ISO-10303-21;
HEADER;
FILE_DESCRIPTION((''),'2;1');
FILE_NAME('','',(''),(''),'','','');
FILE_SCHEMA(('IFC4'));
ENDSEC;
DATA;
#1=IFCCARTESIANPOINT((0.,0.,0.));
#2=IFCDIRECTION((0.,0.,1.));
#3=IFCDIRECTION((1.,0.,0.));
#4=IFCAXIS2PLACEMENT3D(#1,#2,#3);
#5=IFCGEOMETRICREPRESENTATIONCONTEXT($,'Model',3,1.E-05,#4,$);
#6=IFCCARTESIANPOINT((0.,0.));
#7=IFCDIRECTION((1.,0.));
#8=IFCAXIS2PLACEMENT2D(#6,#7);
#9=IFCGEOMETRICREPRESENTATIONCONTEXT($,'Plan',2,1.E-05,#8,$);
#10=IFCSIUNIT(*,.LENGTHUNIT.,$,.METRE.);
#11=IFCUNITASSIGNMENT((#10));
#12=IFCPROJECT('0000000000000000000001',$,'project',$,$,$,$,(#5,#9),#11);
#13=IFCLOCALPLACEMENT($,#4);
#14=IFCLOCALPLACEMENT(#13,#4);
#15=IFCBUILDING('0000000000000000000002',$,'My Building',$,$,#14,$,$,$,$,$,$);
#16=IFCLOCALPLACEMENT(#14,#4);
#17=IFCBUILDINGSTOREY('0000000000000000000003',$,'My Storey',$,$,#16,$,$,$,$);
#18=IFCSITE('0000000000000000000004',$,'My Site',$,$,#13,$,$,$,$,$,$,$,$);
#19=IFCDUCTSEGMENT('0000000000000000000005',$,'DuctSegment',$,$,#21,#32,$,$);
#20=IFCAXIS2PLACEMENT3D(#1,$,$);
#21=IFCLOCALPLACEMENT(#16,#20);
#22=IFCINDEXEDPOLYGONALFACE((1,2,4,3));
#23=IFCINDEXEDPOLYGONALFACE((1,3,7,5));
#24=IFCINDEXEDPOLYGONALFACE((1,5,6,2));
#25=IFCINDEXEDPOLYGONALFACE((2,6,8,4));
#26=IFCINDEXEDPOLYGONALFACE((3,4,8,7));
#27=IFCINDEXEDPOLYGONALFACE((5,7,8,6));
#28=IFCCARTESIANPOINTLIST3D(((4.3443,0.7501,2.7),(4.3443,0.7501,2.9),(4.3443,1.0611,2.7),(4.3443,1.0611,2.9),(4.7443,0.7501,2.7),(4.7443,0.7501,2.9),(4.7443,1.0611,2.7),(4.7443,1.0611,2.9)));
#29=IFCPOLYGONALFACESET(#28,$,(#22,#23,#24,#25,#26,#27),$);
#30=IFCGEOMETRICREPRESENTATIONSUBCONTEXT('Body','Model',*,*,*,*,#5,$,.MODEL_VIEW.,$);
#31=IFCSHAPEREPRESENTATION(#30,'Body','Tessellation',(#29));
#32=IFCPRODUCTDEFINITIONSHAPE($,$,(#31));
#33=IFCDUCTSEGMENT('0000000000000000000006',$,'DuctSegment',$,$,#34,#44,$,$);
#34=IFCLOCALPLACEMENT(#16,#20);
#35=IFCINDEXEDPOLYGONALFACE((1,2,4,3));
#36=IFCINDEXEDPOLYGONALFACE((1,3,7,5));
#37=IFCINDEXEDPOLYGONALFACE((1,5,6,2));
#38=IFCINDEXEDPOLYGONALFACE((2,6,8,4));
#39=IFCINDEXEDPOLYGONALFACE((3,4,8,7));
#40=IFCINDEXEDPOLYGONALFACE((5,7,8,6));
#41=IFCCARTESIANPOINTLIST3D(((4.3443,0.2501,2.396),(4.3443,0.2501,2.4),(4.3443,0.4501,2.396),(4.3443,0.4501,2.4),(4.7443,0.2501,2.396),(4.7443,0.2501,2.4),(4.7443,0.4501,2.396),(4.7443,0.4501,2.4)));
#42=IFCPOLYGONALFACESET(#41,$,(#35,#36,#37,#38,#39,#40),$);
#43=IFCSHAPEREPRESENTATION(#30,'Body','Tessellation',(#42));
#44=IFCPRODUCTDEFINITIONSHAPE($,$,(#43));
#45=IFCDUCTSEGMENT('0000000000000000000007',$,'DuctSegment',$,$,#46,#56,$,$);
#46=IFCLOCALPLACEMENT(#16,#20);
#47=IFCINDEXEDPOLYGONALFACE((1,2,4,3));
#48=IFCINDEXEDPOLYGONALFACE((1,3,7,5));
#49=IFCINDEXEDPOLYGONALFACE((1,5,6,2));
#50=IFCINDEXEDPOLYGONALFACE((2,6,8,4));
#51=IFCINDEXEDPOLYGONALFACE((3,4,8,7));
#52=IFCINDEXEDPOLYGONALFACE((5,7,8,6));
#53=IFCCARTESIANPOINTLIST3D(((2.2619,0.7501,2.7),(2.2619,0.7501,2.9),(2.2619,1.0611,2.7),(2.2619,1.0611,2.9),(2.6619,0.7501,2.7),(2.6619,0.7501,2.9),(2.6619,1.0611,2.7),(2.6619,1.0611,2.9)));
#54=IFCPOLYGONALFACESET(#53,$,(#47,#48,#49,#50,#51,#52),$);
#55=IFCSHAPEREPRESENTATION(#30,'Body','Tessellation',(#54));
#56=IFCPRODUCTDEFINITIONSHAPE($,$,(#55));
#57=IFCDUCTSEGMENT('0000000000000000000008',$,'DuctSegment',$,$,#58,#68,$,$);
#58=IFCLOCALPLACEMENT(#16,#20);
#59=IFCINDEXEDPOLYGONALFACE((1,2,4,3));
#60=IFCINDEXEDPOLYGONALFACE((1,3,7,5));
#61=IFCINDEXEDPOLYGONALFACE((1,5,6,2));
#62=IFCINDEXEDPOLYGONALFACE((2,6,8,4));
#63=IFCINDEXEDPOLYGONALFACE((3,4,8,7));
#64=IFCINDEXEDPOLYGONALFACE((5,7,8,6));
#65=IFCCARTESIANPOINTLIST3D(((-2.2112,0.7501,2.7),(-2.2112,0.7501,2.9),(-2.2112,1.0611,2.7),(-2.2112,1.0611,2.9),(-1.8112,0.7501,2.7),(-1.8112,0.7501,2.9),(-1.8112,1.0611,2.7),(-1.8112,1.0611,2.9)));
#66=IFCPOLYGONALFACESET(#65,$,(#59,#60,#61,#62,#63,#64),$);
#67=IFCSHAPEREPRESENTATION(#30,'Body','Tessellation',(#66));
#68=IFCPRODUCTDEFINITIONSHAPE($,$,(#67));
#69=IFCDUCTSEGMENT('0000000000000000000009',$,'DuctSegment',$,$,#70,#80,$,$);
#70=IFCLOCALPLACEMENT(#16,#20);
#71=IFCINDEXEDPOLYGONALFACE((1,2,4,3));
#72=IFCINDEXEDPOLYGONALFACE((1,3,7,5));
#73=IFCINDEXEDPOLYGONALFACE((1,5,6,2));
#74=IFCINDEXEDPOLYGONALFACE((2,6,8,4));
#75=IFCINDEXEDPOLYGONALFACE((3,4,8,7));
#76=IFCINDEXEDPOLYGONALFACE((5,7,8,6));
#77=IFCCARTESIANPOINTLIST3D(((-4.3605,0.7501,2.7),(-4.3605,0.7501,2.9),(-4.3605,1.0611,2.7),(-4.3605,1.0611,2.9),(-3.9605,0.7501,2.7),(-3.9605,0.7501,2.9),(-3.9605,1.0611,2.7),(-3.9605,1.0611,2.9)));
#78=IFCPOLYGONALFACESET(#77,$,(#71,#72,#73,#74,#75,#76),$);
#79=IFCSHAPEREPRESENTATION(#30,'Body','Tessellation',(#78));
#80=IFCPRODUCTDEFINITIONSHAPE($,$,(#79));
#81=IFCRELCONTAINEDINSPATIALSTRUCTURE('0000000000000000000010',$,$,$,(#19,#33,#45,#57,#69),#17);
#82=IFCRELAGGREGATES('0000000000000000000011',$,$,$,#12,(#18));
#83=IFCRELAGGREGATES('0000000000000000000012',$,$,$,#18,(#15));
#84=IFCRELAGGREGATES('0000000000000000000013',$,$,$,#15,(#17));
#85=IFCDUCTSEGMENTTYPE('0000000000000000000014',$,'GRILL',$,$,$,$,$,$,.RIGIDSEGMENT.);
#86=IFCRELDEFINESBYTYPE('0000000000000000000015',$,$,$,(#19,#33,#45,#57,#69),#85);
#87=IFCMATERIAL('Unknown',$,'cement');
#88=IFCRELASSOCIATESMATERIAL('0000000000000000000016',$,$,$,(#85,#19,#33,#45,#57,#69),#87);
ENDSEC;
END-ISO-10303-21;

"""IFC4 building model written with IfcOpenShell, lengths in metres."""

from ifc_helpers import new_model, si_unit, frame, origin_with_axes, origin_2d_with_axis, place, context, subcontext, project, spatial, rectangle, extrude, material, material_profile, profile_set, profile_usage, type_object, element, save


model = new_model("IFC4")

# Units and contexts
model_context = context("Model", 3, precision=1e-05, world=origin_with_axes())
plan_context = context("Plan", 2, precision=1e-05, world=origin_2d_with_axis())
body_context = subcontext(model_context, "Body", "Model", "MODEL_VIEW")
ifc_project = project(units=[si_unit("LENGTHUNIT", "METRE")], contexts=[model_context, plan_context])

# Site, building, storey
site_placement = place(None, origin_with_axes())
site = spatial("IfcSite", under=ifc_project, at=site_placement, Name="My Site")
building_placement = place(site_placement, origin_with_axes())
building = spatial("IfcBuilding", under=site, at=building_placement, Name="My Building")
storey_placement = place(building_placement, origin_with_axes())
storey = spatial("IfcBuildingStorey", under=building, at=storey_placement, Name="My Storey")

# Duct segments
ifc_material = material(Name="Unknown", Category="cement")
ifc_material_profile_1 = material_profile(ifc_material, rectangle(XDim=0.4, YDim=0.2))
ifc_profile_set_1 = profile_set([ifc_material_profile_1])
ifc_profile_usage_1 = profile_usage(ifc_profile_set_1, cardinal=5)
duct_segment_type = type_object("IfcDuctSegmentType", Name="GRILL", PredefinedType="RIGIDSEGMENT", material=ifc_profile_set_1)
duct_segment_1_placement = place(storey_placement, frame((4.5443, 0.7501, 2.8), z_axis=(0.0, 1.0, 0.0), x_axis=(-1.0, 0.0, 0.0)))
element("IfcDuctSegment", 1, at=duct_segment_1_placement, inside=storey, type_object=duct_segment_type, material=ifc_profile_usage_1, Name="DuctSegment", context=body_context, shape_type="SweptSolid", body=[
    extrude(rectangle(XDim=0.4, YDim=0.2), origin_with_axes(), (0.0, 0.0, 1.0), 0.311),
])
ifc_profile_usage_2 = profile_usage(ifc_profile_set_1, cardinal=5)
duct_segment_2_placement = place(storey_placement, frame((4.5443, 0.3501, 2.396), z_axis=(0.0, 0.0, 1.0), x_axis=(-1.0, 0.0, 0.0)))
element("IfcDuctSegment", 2, at=duct_segment_2_placement, inside=storey, type_object=duct_segment_type, material=ifc_profile_usage_2, Name="DuctSegment", context=body_context, shape_type="SweptSolid", body=[
    extrude(rectangle(XDim=0.4, YDim=0.2), origin_with_axes(), (0.0, 0.0, 1.0), 0.004),
])
ifc_profile_usage_3 = profile_usage(ifc_profile_set_1, cardinal=5)
duct_segment_3_placement = place(storey_placement, frame((2.4619, 0.7501, 2.8), z_axis=(0.0, 1.0, 0.0), x_axis=(-1.0, 0.0, 0.0)))
element("IfcDuctSegment", 3, at=duct_segment_3_placement, inside=storey, type_object=duct_segment_type, material=ifc_profile_usage_3, Name="DuctSegment", context=body_context, shape_type="SweptSolid", body=[
    extrude(rectangle(XDim=0.4, YDim=0.2), origin_with_axes(), (0.0, 0.0, 1.0), 0.311),
])
ifc_profile_usage_4 = profile_usage(ifc_profile_set_1, cardinal=5)
duct_segment_4_placement = place(storey_placement, frame((-2.0112, 0.7501, 2.8), z_axis=(0.0, 1.0, 0.0), x_axis=(-1.0, 0.0, 0.0)))
element("IfcDuctSegment", 4, at=duct_segment_4_placement, inside=storey, type_object=duct_segment_type, material=ifc_profile_usage_4, Name="DuctSegment", context=body_context, shape_type="SweptSolid", body=[
    extrude(rectangle(XDim=0.4, YDim=0.2), origin_with_axes(), (0.0, 0.0, 1.0), 0.311),
])
ifc_profile_usage_5 = profile_usage(ifc_profile_set_1, cardinal=5)
duct_segment_5_placement = place(storey_placement, frame((-4.1605, 0.7501, 2.8), z_axis=(0.0, 1.0, 0.0), x_axis=(-1.0, 0.0, 0.0)))
element("IfcDuctSegment", 5, at=duct_segment_5_placement, inside=storey, type_object=duct_segment_type, material=ifc_profile_usage_5, Name="DuctSegment", context=body_context, shape_type="SweptSolid", body=[
    extrude(rectangle(XDim=0.4, YDim=0.2), origin_with_axes(), (0.0, 0.0, 1.0), 0.311),
])

save(model, "model.ifc")
